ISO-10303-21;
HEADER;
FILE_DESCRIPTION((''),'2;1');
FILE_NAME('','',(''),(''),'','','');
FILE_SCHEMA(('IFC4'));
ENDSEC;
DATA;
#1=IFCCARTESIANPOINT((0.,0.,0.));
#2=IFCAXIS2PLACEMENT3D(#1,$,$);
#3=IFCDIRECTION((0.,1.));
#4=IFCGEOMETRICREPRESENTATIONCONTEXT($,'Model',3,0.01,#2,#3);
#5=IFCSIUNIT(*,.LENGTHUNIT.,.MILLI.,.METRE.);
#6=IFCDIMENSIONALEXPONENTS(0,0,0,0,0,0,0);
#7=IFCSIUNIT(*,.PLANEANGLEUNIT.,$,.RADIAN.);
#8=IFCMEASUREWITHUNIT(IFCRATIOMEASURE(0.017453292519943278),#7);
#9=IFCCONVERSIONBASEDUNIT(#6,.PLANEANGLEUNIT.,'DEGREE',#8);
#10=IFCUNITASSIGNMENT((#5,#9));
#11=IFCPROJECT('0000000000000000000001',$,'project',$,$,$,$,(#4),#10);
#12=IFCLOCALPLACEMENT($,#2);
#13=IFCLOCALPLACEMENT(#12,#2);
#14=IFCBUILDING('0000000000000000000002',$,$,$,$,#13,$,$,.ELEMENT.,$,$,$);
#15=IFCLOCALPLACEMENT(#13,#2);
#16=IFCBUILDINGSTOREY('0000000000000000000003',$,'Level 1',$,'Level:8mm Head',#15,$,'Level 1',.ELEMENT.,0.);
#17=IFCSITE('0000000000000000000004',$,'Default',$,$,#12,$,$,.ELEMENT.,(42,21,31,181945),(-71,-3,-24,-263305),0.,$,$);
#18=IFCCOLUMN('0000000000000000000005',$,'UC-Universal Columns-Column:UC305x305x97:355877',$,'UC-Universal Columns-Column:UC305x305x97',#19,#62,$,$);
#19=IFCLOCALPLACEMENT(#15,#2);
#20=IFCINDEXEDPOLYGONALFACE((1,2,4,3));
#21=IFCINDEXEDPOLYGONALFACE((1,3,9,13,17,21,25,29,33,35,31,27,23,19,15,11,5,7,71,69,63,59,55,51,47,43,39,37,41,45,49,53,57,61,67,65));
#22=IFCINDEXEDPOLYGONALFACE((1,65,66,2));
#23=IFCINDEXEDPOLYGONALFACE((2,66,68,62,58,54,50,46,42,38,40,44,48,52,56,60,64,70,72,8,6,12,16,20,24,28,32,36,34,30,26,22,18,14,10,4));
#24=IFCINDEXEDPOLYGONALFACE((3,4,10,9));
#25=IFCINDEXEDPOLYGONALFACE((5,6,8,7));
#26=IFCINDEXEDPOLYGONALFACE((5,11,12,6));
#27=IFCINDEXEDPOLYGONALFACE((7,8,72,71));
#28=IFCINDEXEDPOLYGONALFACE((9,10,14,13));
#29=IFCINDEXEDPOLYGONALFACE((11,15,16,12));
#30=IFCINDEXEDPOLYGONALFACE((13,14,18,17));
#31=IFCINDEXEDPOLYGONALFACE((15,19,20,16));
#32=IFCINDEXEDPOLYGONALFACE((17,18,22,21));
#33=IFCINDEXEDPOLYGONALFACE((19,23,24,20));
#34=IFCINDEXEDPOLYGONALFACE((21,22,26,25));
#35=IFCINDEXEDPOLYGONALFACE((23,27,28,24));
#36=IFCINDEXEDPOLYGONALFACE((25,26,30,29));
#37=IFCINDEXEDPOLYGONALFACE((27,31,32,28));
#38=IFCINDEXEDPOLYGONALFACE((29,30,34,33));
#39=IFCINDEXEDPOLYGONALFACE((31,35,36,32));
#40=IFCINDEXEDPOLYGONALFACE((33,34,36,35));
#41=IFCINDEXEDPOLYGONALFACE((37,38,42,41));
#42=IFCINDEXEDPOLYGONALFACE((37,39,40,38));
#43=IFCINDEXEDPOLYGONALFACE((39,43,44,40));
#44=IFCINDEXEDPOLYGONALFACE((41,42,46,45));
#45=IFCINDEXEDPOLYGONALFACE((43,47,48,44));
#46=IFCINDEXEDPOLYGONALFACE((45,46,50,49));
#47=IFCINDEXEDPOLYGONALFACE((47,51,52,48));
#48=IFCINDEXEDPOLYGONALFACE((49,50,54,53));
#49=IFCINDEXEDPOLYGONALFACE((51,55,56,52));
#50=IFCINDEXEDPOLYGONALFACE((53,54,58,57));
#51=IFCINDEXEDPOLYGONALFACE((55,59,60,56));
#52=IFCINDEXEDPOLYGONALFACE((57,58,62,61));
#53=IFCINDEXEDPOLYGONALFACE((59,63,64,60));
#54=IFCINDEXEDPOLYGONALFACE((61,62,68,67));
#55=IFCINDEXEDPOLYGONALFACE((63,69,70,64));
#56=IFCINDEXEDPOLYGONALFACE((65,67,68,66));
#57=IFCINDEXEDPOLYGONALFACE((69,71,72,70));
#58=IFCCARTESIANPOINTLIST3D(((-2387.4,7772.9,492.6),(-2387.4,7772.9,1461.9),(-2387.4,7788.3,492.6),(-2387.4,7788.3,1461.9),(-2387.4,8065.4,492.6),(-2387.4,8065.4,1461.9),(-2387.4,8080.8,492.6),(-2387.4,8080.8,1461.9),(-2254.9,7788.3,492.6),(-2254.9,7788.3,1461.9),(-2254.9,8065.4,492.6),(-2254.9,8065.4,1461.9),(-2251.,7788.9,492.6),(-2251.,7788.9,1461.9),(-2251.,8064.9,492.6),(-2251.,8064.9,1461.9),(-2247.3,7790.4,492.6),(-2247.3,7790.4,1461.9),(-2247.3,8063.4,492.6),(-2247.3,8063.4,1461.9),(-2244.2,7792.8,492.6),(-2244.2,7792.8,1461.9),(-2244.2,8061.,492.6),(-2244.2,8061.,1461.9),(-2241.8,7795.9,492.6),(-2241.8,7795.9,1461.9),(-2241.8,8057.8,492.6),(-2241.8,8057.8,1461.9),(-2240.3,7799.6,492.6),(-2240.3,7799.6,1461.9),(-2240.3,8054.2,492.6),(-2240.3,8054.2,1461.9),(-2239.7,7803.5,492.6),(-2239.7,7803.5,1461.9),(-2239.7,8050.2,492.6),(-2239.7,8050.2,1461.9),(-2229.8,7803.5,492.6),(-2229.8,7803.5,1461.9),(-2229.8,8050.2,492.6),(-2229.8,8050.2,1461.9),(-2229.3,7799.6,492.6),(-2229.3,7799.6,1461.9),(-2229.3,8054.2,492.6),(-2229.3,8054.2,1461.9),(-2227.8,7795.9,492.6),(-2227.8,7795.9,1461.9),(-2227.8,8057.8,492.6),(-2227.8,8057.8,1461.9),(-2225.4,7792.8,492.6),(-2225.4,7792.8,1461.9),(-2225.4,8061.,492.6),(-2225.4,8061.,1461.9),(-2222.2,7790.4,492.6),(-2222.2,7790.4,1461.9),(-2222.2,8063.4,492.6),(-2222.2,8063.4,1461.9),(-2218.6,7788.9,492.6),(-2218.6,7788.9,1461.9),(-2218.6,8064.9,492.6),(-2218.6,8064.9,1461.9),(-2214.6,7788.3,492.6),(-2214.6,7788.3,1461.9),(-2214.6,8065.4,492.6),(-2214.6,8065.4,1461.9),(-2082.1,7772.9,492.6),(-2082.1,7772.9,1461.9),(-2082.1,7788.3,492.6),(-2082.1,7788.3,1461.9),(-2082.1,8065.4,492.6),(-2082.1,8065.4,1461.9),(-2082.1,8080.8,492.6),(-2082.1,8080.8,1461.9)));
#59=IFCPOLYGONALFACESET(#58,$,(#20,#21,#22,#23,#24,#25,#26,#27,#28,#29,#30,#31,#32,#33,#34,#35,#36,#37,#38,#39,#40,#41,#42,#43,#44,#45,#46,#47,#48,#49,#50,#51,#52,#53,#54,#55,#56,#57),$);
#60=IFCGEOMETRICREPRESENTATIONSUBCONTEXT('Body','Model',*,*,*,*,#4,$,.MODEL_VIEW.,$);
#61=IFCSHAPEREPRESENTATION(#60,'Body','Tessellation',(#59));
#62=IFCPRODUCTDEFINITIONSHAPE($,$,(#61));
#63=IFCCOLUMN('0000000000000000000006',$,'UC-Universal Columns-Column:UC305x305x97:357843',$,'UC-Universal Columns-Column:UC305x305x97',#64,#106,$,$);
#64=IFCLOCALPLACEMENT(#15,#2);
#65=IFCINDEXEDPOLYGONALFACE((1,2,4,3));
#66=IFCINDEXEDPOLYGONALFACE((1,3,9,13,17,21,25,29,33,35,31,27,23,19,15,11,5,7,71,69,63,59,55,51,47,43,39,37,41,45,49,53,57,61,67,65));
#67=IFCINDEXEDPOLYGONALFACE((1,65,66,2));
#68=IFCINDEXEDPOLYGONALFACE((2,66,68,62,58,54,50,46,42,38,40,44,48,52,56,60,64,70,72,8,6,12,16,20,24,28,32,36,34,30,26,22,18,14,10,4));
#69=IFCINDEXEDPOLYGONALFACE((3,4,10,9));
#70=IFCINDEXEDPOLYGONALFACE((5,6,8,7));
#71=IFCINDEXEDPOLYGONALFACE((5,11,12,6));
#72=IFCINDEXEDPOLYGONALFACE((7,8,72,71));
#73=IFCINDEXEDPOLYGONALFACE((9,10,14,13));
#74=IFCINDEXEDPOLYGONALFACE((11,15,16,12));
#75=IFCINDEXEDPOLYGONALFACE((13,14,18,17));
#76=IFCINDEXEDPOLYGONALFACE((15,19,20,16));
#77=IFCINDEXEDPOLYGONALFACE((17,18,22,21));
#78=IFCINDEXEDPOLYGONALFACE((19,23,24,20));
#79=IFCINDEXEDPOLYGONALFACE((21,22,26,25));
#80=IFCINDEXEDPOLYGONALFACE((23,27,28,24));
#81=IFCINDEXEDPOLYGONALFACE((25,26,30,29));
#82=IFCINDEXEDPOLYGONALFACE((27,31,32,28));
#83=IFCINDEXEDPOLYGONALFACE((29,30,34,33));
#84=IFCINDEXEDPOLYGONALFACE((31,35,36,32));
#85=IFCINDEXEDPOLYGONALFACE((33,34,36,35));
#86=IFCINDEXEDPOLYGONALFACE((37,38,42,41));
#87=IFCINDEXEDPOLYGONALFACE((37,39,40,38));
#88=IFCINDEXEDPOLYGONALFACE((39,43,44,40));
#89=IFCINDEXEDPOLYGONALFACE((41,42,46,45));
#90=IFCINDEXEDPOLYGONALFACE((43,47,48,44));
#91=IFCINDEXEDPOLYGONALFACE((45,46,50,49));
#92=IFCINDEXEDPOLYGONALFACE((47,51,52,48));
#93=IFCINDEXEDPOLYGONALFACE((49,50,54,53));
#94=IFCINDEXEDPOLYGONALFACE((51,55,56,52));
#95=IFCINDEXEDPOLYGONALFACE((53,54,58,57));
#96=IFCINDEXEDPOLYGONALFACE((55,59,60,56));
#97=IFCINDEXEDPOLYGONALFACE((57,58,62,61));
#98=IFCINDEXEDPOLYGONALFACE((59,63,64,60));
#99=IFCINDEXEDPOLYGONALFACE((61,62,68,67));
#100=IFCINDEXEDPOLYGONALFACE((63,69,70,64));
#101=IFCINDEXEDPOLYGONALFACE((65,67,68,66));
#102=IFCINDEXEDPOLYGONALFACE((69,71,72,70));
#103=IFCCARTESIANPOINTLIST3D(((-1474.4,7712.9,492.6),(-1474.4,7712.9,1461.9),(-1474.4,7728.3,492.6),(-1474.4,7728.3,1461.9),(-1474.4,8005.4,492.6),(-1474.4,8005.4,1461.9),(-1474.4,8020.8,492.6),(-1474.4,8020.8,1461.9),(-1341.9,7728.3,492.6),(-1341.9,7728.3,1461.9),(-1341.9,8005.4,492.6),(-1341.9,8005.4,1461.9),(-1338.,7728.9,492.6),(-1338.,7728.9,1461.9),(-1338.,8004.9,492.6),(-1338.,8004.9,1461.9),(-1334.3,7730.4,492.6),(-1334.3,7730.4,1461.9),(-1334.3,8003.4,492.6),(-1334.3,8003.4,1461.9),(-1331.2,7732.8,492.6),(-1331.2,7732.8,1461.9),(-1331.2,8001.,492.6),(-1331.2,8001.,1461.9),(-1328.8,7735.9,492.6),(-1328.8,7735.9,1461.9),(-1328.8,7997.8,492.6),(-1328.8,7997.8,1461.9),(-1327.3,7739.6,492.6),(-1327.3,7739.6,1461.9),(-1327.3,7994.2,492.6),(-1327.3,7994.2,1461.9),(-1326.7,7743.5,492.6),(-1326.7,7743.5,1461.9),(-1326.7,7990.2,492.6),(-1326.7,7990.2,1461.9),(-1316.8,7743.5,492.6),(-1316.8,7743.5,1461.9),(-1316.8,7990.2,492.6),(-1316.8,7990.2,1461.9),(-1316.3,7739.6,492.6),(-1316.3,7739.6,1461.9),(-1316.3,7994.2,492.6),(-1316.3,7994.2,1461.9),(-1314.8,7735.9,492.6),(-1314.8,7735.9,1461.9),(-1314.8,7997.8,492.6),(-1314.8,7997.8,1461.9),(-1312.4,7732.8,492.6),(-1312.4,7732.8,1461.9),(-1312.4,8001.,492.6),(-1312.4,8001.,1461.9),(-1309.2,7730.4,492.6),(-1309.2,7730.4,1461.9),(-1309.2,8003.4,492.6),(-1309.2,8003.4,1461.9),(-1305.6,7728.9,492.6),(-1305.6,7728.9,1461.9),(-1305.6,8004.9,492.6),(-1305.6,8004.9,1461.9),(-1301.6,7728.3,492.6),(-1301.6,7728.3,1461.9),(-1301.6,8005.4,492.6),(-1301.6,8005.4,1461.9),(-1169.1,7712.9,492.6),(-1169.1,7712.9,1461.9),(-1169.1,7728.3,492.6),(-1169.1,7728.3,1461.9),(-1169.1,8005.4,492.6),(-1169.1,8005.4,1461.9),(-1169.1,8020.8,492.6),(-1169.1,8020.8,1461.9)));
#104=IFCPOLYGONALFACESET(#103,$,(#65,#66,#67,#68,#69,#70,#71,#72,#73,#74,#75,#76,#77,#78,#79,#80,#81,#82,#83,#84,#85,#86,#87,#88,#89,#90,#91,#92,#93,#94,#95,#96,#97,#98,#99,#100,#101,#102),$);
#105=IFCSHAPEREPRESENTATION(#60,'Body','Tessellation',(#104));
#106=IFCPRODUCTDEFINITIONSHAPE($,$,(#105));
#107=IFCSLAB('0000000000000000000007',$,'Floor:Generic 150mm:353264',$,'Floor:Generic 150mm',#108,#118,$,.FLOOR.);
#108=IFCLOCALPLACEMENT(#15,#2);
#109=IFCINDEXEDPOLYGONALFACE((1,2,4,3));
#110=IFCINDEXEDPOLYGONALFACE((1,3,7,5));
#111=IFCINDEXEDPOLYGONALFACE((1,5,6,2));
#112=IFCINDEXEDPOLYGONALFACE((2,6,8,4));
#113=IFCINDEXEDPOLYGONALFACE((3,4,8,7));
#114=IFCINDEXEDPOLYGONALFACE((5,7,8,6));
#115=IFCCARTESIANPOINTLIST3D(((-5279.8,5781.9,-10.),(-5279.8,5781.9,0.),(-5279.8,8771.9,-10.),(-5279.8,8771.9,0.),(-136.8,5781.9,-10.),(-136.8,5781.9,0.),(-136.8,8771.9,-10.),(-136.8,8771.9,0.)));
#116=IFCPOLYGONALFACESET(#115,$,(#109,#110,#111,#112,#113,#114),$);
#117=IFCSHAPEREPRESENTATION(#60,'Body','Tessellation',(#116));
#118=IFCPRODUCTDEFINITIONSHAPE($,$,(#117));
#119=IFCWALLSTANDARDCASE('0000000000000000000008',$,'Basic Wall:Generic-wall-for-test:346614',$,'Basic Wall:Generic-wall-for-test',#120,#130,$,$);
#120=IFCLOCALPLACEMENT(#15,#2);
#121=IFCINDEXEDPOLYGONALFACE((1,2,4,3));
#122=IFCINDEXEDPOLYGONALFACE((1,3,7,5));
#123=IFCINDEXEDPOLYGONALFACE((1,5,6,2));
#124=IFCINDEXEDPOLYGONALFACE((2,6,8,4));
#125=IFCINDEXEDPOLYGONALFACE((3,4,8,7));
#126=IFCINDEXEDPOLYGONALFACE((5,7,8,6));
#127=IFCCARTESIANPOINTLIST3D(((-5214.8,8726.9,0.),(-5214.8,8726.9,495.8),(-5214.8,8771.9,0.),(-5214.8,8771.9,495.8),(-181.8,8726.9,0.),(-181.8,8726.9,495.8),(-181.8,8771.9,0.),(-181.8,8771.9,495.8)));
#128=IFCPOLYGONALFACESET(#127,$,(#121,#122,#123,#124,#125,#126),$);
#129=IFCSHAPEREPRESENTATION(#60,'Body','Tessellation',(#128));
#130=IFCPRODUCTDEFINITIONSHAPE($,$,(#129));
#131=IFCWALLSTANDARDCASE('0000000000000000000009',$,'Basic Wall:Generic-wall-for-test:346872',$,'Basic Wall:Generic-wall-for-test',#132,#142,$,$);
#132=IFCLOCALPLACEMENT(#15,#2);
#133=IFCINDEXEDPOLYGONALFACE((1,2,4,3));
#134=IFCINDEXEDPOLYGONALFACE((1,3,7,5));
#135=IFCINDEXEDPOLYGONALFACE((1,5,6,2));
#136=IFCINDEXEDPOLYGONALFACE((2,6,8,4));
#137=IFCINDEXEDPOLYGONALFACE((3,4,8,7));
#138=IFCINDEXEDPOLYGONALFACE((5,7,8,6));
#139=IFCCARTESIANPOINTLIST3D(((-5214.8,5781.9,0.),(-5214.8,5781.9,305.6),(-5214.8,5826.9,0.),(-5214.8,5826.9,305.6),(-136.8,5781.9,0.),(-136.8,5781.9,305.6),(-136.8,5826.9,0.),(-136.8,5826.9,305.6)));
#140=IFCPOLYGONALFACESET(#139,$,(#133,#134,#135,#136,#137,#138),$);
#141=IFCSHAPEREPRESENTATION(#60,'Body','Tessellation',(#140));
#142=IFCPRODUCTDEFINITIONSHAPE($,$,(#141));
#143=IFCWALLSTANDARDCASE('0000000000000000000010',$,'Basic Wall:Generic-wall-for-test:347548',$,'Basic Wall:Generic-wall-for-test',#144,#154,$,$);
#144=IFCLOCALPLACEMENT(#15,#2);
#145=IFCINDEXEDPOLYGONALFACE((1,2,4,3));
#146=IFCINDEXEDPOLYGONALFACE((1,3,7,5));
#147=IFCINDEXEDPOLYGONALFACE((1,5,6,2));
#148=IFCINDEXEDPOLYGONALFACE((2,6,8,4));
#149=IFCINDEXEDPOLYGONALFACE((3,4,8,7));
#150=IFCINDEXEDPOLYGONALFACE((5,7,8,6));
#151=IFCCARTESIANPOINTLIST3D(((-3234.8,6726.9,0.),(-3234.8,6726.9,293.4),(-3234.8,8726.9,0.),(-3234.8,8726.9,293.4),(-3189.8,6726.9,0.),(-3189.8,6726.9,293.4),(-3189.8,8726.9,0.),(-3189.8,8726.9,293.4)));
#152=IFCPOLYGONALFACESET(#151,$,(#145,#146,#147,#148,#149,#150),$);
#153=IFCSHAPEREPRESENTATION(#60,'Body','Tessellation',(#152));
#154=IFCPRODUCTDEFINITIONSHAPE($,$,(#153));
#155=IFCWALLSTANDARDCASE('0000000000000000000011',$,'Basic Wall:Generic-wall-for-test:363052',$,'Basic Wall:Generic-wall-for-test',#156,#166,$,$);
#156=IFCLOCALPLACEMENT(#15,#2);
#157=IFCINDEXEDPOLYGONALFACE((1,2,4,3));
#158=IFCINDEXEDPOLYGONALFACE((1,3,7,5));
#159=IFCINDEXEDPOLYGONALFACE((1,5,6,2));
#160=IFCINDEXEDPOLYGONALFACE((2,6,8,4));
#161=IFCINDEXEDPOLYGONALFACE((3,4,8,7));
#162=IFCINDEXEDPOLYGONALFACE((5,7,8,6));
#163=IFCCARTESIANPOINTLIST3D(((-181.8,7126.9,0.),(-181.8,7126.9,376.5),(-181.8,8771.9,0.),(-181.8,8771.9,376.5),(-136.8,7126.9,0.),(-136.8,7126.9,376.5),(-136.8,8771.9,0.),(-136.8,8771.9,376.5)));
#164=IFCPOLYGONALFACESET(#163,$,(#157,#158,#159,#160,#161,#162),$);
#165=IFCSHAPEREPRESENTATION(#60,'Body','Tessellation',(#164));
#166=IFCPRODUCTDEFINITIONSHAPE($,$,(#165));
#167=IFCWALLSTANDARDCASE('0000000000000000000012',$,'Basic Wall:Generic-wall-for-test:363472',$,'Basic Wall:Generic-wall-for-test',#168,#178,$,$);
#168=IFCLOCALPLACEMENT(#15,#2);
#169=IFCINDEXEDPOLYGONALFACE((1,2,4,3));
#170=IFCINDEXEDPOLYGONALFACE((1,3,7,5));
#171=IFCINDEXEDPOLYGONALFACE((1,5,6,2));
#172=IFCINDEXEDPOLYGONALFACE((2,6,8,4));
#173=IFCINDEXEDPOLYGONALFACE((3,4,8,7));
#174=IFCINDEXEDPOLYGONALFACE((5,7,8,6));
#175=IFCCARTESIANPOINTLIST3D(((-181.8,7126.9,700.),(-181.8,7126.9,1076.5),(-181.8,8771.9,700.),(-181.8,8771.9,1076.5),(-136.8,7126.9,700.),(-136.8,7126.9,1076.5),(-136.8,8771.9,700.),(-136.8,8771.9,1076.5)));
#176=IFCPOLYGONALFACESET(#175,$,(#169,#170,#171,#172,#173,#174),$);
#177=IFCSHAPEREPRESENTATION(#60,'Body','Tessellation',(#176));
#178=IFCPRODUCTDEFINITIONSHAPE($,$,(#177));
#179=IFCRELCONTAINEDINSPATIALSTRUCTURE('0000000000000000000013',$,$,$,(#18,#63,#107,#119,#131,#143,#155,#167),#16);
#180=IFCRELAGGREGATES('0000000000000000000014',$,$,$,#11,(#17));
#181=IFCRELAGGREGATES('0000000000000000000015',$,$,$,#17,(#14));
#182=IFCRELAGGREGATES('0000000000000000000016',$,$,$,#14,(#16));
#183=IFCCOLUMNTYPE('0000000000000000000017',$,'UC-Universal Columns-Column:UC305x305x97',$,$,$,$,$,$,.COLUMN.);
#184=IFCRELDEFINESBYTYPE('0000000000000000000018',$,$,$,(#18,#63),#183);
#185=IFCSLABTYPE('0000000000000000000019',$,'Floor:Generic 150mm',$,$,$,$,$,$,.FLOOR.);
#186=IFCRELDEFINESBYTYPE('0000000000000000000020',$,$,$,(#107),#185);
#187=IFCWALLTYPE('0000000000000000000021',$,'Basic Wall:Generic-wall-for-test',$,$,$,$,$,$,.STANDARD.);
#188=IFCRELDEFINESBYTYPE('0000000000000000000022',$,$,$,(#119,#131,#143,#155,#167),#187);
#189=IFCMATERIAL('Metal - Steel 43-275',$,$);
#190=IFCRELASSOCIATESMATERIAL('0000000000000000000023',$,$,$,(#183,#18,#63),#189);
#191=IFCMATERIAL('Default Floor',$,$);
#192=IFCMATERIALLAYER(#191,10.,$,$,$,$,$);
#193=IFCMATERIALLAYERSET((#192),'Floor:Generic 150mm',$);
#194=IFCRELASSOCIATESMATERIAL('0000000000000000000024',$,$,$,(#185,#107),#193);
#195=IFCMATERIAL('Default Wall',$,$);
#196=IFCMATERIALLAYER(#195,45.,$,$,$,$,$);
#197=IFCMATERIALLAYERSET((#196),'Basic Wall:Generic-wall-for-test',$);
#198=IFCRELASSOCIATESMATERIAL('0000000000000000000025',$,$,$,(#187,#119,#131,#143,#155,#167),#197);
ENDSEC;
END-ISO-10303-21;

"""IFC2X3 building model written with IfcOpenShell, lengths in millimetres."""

from ifc_helpers import new_model, entity, si_unit, converted_unit, direction, frame, frame_2d, origin, place, context, subcontext, project, spatial, rectangle, i_section, extrude, source, transform, mapped, material, layer, layer_set, layer_usage, type_object, type_shapes, element, save


model = new_model("IFC2X3")

# Units and contexts
model_context = context("Model", 3, precision=0.01, world=origin(), true_north=direction((0.0, 1.0)))
body_context = subcontext(model_context, "Body", "Model", "MODEL_VIEW")
ifc_project = project(units=[si_unit("LENGTHUNIT", "METRE", prefix="MILLI"), converted_unit("PLANEANGLEUNIT", "DEGREE", entity("IfcRatioMeasure", 0.017453292519943278), si_unit("PLANEANGLEUNIT", "RADIAN"), dimensions=[0, 0, 0, 0, 0, 0, 0])], contexts=[model_context])

# Site, building, storey
site_placement = place(None, origin())
site = spatial("IfcSite", under=ifc_project, at=site_placement, Name="Default", CompositionType="ELEMENT", RefLatitude=(42, 21, 31, 181945), RefLongitude=(-71, -3, -24, -263305), RefElevation=0.0)
building_placement = place(site_placement, origin())
building = spatial("IfcBuilding", under=site, at=building_placement, CompositionType="ELEMENT")
storey_placement = place(building_placement, origin())
storey = spatial("IfcBuildingStorey", under=building, at=storey_placement, Name="Level 1", ObjectType="Level:8mm Head", LongName="Level 1", CompositionType="ELEMENT", Elevation=0.0)

# Columns
ifc_material_1 = material(Name="Metal - Steel 43-275")
column_type = type_object("IfcColumnType", Name="UC-Universal Columns-Column:UC305x305x97", PredefinedType="COLUMN", material=ifc_material_1)
shared_shape = source(origin(), body_context, "Body", "SweptSolid", [
    extrude(i_section(OverallWidth=305.3, OverallDepth=307.9, WebThickness=9.9, FlangeThickness=15.4, FilletRadius=15.2, at=frame_2d((0.0, 0.0), x_axis=(0.0, 1.0))), frame((0.0, 0.0, 492.6), z_axis=(0.0, 0.0, 1.0), x_axis=(0.0, -1.0, 0.0)), (0.0, 0.0, 1.0), 969.3),
])
type_shapes(column_type, [shared_shape])
for number, where, name in (
    (1, (-2234.8, 7926.9, 0.0), "UC-Universal Columns-Column:UC305x305x97:355877"),
    (2, (-1321.8, 7866.9, 0.0), "UC-Universal Columns-Column:UC305x305x97:357843"),
):
    element("IfcColumn", number, at=place(storey_placement, frame(where)), inside=storey, type_object=column_type, material=ifc_material_1, Name=name, ObjectType="UC-Universal Columns-Column:UC305x305x97", context=body_context, shape_type="MappedRepresentation", body=[
        mapped(shared_shape, transform((0.0, 0.0, 0.0), scale=1.0)),
    ])

# Slab
ifc_material_2 = material(Name="Default Floor")
ifc_layer_1 = layer(ifc_material_2, 10.0)
ifc_layer_set_1 = layer_set([ifc_layer_1], Name="Floor:Generic 150mm")
ifc_layer_usage_1 = layer_usage(ifc_layer_set_1, "AXIS3", "POSITIVE", 0.0)
slab_type = type_object("IfcSlabType", Name="Floor:Generic 150mm", PredefinedType="FLOOR", material=ifc_layer_set_1)
slab_placement = place(storey_placement, origin())
element("IfcSlab", 3, at=slab_placement, inside=storey, type_object=slab_type, material=ifc_layer_usage_1, Name="Floor:Generic 150mm:353264", ObjectType="Floor:Generic 150mm", PredefinedType="FLOOR", context=body_context, shape_type="SweptSolid", body=[
    extrude(rectangle(XDim=2990.0, YDim=5143.0, at=frame_2d((0.0, 0.0), x_axis=(1.0, 0.0))), frame((-2708.3, 7276.9, 0.0), z_axis=(0.0, 0.0, -1.0), x_axis=(0.0, 1.0, 0.0)), (0.0, 0.0, 1.0), 10.0),
])

# Walls
ifc_material_3 = material(Name="Default Wall")
ifc_layer_2 = layer(ifc_material_3, 45.0)
ifc_layer_set_2 = layer_set([ifc_layer_2], Name="Basic Wall:Generic-wall-for-test")
ifc_layer_usage_2 = layer_usage(ifc_layer_set_2, "AXIS2", "NEGATIVE", 22.5)
wall_type = type_object("IfcWallType", Name="Basic Wall:Generic-wall-for-test", PredefinedType="STANDARD", material=ifc_layer_set_2)
wall_1_placement = place(storey_placement, frame((-5214.8, 8749.4, 0.0)))
element("IfcWallStandardCase", 4, at=wall_1_placement, inside=storey, type_object=wall_type, material=ifc_layer_usage_2, Name="Basic Wall:Generic-wall-for-test:346614", ObjectType="Basic Wall:Generic-wall-for-test", context=body_context, shape_type="SweptSolid", body=[
    extrude(rectangle(XDim=5033.0, YDim=45.0, at=frame_2d((2516.5, 0.0), x_axis=(-1.0, 0.0))), origin(), (0.0, 0.0, 1.0), 495.8),
])
wall_2_placement = place(storey_placement, frame((-136.8, 5804.4, 0.0), z_axis=(0.0, 0.0, 1.0), x_axis=(-1.0, 0.0, 0.0)))
element("IfcWallStandardCase", 5, at=wall_2_placement, inside=storey, type_object=wall_type, material=ifc_layer_usage_2, Name="Basic Wall:Generic-wall-for-test:346872", ObjectType="Basic Wall:Generic-wall-for-test", context=body_context, shape_type="SweptSolid", body=[
    extrude(rectangle(XDim=5078.0, YDim=45.0, at=frame_2d((2539.0, 0.0), x_axis=(-1.0, 0.0))), origin(), (0.0, 0.0, 1.0), 305.6),
])
wall_3_placement = place(storey_placement, frame((-3212.3, 8726.9, 0.0), z_axis=(0.0, 0.0, 1.0), x_axis=(0.0, -1.0, 0.0)))
element("IfcWallStandardCase", 6, at=wall_3_placement, inside=storey, type_object=wall_type, material=ifc_layer_usage_2, Name="Basic Wall:Generic-wall-for-test:347548", ObjectType="Basic Wall:Generic-wall-for-test", context=body_context, shape_type="SweptSolid", body=[
    extrude(rectangle(XDim=2000.0, YDim=45.0, at=frame_2d((1000.0, 0.0), x_axis=(-1.0, 0.0))), origin(), (0.0, 0.0, 1.0), 293.4),
])

# Walls
for number, where, z_axis, x_axis, name in (
    (7, (-159.3, 8771.9, 0.0), (0.0, 0.0, 1.0), (0.0, -1.0, 0.0), "Basic Wall:Generic-wall-for-test:363052"),
    (8, (-159.3, 8771.9, 700.0), (0.0, 0.0, 1.0), (0.0, -1.0, 0.0), "Basic Wall:Generic-wall-for-test:363472"),
):
    element("IfcWallStandardCase", number, at=place(storey_placement, frame(where, z_axis=z_axis, x_axis=x_axis)), inside=storey, type_object=wall_type, material=ifc_layer_usage_2, Name=name, ObjectType="Basic Wall:Generic-wall-for-test", context=body_context, shape_type="SweptSolid", body=[
        extrude(rectangle(XDim=1645.0, YDim=45.0, at=frame_2d((822.5, 0.0), x_axis=(-1.0, 0.0))), origin(), (0.0, 0.0, 1.0), 376.5),
    ])

save(model, "model.ifc")
